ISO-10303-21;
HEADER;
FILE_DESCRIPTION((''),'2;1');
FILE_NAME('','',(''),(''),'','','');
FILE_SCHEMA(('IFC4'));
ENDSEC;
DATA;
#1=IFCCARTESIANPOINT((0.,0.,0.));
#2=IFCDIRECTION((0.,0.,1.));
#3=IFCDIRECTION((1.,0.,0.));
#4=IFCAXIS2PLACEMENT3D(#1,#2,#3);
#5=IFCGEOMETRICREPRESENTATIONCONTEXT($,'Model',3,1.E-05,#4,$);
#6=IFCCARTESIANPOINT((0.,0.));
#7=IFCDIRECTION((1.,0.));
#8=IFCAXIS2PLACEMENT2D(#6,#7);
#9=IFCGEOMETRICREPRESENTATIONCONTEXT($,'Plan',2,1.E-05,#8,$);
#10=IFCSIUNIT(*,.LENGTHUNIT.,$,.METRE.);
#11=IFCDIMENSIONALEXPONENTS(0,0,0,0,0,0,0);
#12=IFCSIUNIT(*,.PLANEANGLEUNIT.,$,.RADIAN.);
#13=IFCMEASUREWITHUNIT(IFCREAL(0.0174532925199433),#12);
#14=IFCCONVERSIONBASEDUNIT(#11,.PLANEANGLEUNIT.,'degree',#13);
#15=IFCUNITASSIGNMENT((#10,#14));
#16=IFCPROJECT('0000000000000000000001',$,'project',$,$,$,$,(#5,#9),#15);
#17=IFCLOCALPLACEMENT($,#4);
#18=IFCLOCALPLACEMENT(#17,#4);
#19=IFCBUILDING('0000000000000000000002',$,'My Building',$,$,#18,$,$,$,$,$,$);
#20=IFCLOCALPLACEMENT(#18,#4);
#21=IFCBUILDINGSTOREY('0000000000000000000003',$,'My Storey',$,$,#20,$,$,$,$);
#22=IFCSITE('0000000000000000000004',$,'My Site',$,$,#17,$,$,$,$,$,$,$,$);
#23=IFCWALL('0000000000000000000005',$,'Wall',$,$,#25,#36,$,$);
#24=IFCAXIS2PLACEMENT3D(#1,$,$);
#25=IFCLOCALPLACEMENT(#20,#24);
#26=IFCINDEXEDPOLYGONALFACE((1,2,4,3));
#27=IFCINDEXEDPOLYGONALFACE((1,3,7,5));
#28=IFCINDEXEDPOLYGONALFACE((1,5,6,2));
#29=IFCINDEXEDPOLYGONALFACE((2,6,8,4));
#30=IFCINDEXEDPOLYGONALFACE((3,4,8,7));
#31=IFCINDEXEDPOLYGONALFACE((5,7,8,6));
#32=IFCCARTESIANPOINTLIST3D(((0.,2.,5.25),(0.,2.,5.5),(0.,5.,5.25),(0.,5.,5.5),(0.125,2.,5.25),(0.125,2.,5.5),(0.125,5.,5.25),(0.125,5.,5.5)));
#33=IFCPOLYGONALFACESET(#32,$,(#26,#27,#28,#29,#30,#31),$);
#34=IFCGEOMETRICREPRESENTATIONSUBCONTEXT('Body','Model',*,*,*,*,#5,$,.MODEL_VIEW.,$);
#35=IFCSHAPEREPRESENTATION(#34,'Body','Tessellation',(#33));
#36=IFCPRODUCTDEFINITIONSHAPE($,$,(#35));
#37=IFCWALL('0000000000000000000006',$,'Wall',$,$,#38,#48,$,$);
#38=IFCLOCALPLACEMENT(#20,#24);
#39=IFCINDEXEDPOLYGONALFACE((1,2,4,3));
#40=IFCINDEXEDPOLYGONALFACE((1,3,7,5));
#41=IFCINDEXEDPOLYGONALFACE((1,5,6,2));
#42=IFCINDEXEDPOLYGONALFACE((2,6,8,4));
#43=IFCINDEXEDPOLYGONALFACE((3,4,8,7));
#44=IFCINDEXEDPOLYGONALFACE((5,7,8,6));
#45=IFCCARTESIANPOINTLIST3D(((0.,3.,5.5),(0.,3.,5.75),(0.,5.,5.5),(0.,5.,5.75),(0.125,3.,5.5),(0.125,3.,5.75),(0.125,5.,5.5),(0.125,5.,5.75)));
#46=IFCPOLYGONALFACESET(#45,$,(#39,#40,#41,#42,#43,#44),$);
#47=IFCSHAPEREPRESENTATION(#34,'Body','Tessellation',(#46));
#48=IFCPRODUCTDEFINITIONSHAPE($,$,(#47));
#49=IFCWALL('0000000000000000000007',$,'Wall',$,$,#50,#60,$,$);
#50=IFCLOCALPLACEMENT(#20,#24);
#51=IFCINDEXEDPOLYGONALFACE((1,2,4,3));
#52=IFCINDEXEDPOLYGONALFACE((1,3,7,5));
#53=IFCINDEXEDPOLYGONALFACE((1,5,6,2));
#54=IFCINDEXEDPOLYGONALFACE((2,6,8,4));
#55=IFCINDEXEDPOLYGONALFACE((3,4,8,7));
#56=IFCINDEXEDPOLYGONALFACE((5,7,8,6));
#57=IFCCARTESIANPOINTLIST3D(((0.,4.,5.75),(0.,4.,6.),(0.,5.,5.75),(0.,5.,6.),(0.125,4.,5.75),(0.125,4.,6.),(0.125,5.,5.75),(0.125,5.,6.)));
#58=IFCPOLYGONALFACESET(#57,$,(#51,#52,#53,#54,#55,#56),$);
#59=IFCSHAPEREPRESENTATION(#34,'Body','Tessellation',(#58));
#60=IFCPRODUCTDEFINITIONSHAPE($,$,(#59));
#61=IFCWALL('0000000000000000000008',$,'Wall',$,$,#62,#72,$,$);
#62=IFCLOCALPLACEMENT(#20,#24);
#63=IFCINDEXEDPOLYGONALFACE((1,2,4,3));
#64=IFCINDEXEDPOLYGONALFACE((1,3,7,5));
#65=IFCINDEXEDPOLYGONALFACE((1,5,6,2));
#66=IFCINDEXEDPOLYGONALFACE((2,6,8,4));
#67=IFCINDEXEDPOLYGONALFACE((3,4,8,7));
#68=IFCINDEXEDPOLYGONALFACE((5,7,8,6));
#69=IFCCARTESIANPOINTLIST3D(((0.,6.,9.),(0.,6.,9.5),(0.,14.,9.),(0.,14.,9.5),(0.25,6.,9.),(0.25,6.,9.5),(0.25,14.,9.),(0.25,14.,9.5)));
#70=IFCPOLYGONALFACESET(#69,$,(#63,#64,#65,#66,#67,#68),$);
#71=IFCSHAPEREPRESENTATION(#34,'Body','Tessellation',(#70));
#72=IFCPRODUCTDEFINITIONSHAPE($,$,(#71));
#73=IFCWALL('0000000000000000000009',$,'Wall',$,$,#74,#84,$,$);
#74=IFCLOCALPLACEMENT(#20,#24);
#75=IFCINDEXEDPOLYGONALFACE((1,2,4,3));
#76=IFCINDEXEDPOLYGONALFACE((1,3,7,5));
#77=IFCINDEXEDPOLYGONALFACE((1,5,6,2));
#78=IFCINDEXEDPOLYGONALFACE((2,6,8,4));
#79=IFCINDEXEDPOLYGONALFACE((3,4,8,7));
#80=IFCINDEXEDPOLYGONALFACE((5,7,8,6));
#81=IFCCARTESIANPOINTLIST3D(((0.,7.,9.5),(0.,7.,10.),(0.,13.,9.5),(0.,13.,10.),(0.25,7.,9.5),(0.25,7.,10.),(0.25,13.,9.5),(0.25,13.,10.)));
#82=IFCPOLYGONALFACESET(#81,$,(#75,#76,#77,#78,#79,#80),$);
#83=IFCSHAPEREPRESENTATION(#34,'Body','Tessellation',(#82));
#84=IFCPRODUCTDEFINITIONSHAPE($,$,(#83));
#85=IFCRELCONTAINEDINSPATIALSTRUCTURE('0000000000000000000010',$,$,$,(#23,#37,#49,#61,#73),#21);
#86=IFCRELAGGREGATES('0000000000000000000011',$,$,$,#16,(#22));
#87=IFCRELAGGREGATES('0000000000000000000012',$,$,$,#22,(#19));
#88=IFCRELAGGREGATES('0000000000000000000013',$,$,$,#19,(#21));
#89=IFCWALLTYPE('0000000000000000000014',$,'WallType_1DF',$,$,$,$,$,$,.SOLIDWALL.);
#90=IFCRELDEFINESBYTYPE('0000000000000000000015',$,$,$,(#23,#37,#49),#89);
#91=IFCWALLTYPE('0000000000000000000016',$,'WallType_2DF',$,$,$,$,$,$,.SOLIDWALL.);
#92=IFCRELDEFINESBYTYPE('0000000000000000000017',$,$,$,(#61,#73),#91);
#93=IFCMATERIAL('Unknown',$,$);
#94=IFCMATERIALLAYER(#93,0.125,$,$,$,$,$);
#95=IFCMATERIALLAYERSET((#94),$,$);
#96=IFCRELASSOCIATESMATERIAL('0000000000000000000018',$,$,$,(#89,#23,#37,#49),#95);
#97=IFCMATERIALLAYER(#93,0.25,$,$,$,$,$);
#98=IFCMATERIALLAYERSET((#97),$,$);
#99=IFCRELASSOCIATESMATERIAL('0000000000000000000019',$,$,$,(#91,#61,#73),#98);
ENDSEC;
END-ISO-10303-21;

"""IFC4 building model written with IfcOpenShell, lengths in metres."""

from ifc_helpers import new_model, entity, si_unit, converted_unit, frame, origin_with_axes, origin_2d_with_axis, place, context, subcontext, project, spatial, indexed_curve, outline, extrude, material, layer, layer_set, layer_usage, type_object, element, save


model = new_model("IFC4")

# Units and contexts
model_context = context("Model", 3, precision=1e-05, world=origin_with_axes())
plan_context = context("Plan", 2, precision=1e-05, world=origin_2d_with_axis())
body_context = subcontext(model_context, "Body", "Model", "MODEL_VIEW")
ifc_project = project(units=[si_unit("LENGTHUNIT", "METRE"), converted_unit("PLANEANGLEUNIT", "degree", entity("IfcReal", 0.0174532925199433), si_unit("PLANEANGLEUNIT", "RADIAN"), dimensions=[0, 0, 0, 0, 0, 0, 0])], contexts=[model_context, plan_context])

# Site, building, storey
site_placement = place(None, origin_with_axes())
site = spatial("IfcSite", under=ifc_project, at=site_placement, Name="My Site")
building_placement = place(site_placement, origin_with_axes())
building = spatial("IfcBuilding", under=site, at=building_placement, Name="My Building")
storey_placement = place(building_placement, origin_with_axes())
storey = spatial("IfcBuildingStorey", under=building, at=storey_placement, Name="My Storey")

# Walls
ifc_material = material(Name="Unknown")
ifc_layer_1 = layer(ifc_material, 0.125)
ifc_layer_set_1 = layer_set([ifc_layer_1])
ifc_layer_usage_1 = layer_usage(ifc_layer_set_1, "AXIS2", "POSITIVE", 0.0)
wall_type_1 = type_object("IfcWallType", Name="WallType_1DF", PredefinedType="SOLIDWALL", material=ifc_layer_set_1)
wall_1_placement = place(storey_placement, frame((0.125, 2.0, 5.25), z_axis=(0.0, 0.0, 1.0), x_axis=(0.0, 1.0, 0.0)))
element("IfcWall", 1, at=wall_1_placement, inside=storey, type_object=wall_type_1, material=ifc_layer_usage_1, Name="Wall", context=body_context, shape_type="SweptSolid", body=[
    extrude(outline(indexed_curve([(0.0, 0.0), (0.0, 0.125), (3.0, 0.125), (3.0, 0.0), (0.0, 0.0)], self_intersect=False)), origin_with_axes(), (0.0, 0.0, 1.0), 0.25),
])
ifc_layer_usage_2 = layer_usage(ifc_layer_set_1, "AXIS2", "POSITIVE", 0.0)
wall_2_placement = place(storey_placement, frame((0.125, 3.0, 5.5), z_axis=(0.0, 0.0, 1.0), x_axis=(0.0, 1.0, 0.0)))
element("IfcWall", 2, at=wall_2_placement, inside=storey, type_object=wall_type_1, material=ifc_layer_usage_2, Name="Wall", context=body_context, shape_type="SweptSolid", body=[
    extrude(outline(indexed_curve([(0.0, 0.0), (0.0, 0.125), (2.0, 0.125), (2.0, 0.0), (0.0, 0.0)], self_intersect=False)), origin_with_axes(), (0.0, 0.0, 1.0), 0.25),
])
ifc_layer_usage_3 = layer_usage(ifc_layer_set_1, "AXIS2", "POSITIVE", 0.0)
wall_3_placement = place(storey_placement, frame((0.125, 4.0, 5.75), z_axis=(0.0, 0.0, 1.0), x_axis=(0.0, 1.0, 0.0)))
element("IfcWall", 3, at=wall_3_placement, inside=storey, type_object=wall_type_1, material=ifc_layer_usage_3, Name="Wall", context=body_context, shape_type="SweptSolid", body=[
    extrude(outline(indexed_curve([(0.0, 0.0), (0.0, 0.125), (1.0, 0.125), (1.0, 0.0), (0.0, 0.0)], self_intersect=False)), origin_with_axes(), (0.0, 0.0, 1.0), 0.25),
])
ifc_layer_2 = layer(ifc_material, 0.25)
ifc_layer_set_2 = layer_set([ifc_layer_2])
ifc_layer_usage_4 = layer_usage(ifc_layer_set_2, "AXIS2", "POSITIVE", 0.0)
wall_type_2 = type_object("IfcWallType", Name="WallType_2DF", PredefinedType="SOLIDWALL", material=ifc_layer_set_2)
wall_4_placement = place(storey_placement, frame((0.25, 6.0, 9.0), z_axis=(0.0, 0.0, 1.0), x_axis=(0.0, 1.0, 0.0)))
element("IfcWall", 4, at=wall_4_placement, inside=storey, type_object=wall_type_2, material=ifc_layer_usage_4, Name="Wall", context=body_context, shape_type="SweptSolid", body=[
    extrude(outline(indexed_curve([(0.0, 0.0), (0.0, 0.25), (8.0, 0.25), (8.0, 0.0), (0.0, 0.0)], self_intersect=False)), origin_with_axes(), (0.0, 0.0, 1.0), 0.5),
])
ifc_layer_usage_5 = layer_usage(ifc_layer_set_2, "AXIS2", "POSITIVE", 0.0)
wall_5_placement = place(storey_placement, frame((0.25, 7.0, 9.5), z_axis=(0.0, 0.0, 1.0), x_axis=(0.0, 1.0, 0.0)))
element("IfcWall", 5, at=wall_5_placement, inside=storey, type_object=wall_type_2, material=ifc_layer_usage_5, Name="Wall", context=body_context, shape_type="SweptSolid", body=[
    extrude(outline(indexed_curve([(0.0, 0.0), (0.0, 0.25), (6.0, 0.25), (6.0, 0.0), (0.0, 0.0)], self_intersect=False)), origin_with_axes(), (0.0, 0.0, 1.0), 0.5),
])

save(model, "model.ifc")
